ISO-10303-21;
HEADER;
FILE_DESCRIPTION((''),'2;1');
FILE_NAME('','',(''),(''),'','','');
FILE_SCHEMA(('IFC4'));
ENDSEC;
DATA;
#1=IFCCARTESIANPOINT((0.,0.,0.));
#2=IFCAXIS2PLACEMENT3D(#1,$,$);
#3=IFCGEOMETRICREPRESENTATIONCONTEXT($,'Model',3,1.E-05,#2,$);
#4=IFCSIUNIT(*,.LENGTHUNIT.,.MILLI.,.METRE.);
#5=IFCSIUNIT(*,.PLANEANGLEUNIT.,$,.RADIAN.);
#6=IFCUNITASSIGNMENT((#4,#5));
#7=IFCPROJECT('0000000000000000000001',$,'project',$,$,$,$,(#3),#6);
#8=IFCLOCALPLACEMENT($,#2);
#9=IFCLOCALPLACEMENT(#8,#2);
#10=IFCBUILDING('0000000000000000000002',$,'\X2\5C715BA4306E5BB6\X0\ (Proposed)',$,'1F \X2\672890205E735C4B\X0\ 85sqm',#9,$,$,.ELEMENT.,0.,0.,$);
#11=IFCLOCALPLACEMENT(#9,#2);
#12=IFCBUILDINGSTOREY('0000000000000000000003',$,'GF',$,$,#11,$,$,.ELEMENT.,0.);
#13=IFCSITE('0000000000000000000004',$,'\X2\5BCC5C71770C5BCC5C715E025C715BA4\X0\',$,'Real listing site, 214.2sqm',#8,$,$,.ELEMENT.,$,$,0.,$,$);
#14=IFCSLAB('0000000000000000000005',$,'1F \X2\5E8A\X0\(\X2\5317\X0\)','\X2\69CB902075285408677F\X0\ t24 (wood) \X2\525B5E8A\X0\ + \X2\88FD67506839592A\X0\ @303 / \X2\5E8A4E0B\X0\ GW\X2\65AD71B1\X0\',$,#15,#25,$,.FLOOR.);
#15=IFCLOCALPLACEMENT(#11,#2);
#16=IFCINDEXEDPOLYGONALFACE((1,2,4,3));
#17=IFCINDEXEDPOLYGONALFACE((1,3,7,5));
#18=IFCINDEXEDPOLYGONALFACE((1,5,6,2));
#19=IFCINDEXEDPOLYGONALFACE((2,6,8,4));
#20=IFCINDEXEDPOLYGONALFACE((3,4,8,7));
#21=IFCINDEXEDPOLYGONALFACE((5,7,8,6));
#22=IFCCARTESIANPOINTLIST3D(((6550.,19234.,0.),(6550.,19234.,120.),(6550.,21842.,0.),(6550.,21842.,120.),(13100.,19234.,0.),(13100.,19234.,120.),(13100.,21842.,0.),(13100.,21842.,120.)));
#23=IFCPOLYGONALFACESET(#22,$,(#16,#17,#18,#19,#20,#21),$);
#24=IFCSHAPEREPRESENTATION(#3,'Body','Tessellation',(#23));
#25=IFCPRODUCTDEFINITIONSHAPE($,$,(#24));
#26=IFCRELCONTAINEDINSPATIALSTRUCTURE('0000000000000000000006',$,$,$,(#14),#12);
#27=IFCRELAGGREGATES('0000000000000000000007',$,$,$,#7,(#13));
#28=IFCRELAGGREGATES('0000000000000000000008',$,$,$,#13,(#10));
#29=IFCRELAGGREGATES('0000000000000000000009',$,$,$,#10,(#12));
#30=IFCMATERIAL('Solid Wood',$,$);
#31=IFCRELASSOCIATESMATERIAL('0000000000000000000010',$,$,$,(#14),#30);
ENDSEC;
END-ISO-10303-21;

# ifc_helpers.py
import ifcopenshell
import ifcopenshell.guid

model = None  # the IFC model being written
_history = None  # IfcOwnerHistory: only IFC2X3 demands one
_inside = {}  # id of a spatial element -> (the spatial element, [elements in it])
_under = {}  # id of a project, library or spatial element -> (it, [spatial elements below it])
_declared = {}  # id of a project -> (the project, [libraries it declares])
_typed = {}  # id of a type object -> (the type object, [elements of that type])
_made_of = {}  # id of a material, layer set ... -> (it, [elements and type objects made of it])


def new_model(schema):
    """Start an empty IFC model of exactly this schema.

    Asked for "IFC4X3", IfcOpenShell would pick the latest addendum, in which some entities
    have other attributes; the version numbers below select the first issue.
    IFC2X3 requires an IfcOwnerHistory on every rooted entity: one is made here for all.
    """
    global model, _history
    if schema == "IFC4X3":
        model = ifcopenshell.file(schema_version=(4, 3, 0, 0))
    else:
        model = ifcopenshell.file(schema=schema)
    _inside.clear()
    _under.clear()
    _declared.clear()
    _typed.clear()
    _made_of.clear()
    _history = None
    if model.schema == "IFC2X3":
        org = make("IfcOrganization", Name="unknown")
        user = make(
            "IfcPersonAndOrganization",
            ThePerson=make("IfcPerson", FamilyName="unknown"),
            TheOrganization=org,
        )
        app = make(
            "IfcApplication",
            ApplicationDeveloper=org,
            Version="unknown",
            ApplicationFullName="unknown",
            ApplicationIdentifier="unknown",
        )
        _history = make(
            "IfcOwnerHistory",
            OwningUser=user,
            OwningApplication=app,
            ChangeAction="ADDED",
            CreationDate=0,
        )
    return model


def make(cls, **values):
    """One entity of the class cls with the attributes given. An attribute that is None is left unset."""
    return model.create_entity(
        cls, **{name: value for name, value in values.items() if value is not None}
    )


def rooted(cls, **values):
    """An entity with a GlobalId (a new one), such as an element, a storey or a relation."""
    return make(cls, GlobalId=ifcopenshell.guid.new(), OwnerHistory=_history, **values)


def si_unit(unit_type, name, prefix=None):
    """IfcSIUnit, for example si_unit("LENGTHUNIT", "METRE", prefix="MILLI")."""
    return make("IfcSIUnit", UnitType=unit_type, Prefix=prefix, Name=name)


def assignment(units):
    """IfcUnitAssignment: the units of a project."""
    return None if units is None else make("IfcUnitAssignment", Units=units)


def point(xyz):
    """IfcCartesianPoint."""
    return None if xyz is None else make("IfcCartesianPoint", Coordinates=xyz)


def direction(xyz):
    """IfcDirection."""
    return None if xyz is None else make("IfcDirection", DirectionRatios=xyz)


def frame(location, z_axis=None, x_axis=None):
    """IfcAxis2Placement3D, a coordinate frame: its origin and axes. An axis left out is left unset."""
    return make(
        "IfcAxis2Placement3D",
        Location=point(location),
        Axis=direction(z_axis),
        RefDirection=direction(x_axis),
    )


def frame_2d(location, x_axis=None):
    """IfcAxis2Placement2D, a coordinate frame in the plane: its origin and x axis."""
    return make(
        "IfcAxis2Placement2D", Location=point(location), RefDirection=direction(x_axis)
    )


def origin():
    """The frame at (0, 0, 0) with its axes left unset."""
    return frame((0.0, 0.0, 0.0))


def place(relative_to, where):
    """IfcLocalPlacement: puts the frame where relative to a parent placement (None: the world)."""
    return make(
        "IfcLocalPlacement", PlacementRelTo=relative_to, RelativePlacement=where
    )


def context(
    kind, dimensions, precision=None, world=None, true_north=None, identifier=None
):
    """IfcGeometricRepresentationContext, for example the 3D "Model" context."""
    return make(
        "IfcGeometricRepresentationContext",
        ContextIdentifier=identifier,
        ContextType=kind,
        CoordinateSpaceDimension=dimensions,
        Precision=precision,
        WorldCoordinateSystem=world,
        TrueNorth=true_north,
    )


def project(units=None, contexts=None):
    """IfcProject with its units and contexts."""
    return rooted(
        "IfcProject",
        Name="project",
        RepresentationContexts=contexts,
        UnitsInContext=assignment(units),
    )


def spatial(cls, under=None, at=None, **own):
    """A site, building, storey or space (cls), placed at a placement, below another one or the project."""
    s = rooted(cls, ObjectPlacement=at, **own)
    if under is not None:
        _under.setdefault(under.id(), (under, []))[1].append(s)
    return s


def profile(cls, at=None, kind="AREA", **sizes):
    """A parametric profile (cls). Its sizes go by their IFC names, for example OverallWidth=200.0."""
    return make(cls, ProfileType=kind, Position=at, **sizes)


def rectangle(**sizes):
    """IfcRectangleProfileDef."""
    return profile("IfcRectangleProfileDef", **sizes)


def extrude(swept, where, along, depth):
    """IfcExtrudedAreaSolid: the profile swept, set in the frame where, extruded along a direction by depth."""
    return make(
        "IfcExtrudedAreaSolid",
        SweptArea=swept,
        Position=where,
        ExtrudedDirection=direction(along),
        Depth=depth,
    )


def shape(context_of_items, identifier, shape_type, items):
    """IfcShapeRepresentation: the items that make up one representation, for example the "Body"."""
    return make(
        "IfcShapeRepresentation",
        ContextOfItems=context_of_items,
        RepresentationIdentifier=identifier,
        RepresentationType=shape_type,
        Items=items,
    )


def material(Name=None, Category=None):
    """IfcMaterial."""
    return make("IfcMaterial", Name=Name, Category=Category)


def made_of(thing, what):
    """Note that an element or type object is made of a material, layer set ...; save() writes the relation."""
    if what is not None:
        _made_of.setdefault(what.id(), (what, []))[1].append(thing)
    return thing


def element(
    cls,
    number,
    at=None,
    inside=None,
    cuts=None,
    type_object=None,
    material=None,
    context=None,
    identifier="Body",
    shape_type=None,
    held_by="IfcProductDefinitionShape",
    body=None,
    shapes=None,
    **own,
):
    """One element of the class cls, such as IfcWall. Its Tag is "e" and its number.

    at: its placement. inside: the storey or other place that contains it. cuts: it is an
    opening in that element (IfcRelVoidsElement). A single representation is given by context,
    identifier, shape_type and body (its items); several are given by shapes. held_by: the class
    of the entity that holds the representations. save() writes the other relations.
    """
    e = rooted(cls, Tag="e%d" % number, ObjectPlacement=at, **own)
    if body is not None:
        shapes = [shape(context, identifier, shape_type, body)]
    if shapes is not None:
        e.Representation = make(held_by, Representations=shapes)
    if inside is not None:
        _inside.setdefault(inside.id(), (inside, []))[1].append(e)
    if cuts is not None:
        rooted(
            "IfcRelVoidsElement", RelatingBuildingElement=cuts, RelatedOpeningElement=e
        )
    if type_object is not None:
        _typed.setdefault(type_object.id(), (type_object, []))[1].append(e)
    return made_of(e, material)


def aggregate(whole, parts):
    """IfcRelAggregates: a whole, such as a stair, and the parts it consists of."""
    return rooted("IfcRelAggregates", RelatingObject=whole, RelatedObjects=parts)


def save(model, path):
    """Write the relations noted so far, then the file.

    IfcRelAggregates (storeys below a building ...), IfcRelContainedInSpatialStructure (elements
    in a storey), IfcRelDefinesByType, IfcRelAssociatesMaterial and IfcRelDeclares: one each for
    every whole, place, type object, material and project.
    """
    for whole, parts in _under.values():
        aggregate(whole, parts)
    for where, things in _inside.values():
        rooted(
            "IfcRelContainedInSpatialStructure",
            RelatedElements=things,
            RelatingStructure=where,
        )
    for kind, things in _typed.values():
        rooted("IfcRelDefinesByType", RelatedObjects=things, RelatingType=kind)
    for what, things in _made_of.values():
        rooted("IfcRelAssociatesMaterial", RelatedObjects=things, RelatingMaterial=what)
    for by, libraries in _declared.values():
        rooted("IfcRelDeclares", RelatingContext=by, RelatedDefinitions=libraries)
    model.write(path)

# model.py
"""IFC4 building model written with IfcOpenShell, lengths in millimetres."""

from ifc_helpers import new_model, si_unit, frame, frame_2d, origin, place, context, project, spatial, rectangle, extrude, material, element, save


model = new_model("IFC4")

# Units and contexts
model_context = context("Model", 3, precision=1e-05, world=origin())
ifc_project = project(units=[si_unit("LENGTHUNIT", "METRE", prefix="MILLI"), si_unit("PLANEANGLEUNIT", "RADIAN")], contexts=[model_context])

# Site, building, storey
site_placement = place(None, origin())
site = spatial("IfcSite", under=ifc_project, at=site_placement, Name="富山県富山市山室", ObjectType="Real listing site, 214.2sqm", CompositionType="ELEMENT", RefElevation=0.0)
building_placement = place(site_placement, origin())
building = spatial("IfcBuilding", under=site, at=building_placement, Name="山室の家 (Proposed)", ObjectType="1F 木造平屋 85sqm", CompositionType="ELEMENT", ElevationOfRefHeight=0.0, ElevationOfTerrain=0.0)
storey_placement = place(building_placement, origin())
storey = spatial("IfcBuildingStorey", under=building, at=storey_placement, Name="GF", CompositionType="ELEMENT", Elevation=0.0)

# Slab
ifc_material_1 = material(Name="Solid Wood")
slab_1_placement = place(storey_placement, frame((3275.0, 9617.0, 0.0)))
element("IfcSlab", 1, at=slab_1_placement, inside=storey, material=ifc_material_1, Name="1F 床(北)", Description="構造用合板 t24 (wood) 剛床 + 製材根太 @303 / 床下 GW断熱", PredefinedType="FLOOR", context=model_context, shape_type="SweptSolid", body=[
    extrude(rectangle(XDim=6550.0, YDim=2608.0, at=frame_2d((3275.0, 1304.0))), frame((3275.0, 9617.0, 0.0)), (0.0, 0.0, 1.0), 120.0),
])

save(model, "model.ifc")
